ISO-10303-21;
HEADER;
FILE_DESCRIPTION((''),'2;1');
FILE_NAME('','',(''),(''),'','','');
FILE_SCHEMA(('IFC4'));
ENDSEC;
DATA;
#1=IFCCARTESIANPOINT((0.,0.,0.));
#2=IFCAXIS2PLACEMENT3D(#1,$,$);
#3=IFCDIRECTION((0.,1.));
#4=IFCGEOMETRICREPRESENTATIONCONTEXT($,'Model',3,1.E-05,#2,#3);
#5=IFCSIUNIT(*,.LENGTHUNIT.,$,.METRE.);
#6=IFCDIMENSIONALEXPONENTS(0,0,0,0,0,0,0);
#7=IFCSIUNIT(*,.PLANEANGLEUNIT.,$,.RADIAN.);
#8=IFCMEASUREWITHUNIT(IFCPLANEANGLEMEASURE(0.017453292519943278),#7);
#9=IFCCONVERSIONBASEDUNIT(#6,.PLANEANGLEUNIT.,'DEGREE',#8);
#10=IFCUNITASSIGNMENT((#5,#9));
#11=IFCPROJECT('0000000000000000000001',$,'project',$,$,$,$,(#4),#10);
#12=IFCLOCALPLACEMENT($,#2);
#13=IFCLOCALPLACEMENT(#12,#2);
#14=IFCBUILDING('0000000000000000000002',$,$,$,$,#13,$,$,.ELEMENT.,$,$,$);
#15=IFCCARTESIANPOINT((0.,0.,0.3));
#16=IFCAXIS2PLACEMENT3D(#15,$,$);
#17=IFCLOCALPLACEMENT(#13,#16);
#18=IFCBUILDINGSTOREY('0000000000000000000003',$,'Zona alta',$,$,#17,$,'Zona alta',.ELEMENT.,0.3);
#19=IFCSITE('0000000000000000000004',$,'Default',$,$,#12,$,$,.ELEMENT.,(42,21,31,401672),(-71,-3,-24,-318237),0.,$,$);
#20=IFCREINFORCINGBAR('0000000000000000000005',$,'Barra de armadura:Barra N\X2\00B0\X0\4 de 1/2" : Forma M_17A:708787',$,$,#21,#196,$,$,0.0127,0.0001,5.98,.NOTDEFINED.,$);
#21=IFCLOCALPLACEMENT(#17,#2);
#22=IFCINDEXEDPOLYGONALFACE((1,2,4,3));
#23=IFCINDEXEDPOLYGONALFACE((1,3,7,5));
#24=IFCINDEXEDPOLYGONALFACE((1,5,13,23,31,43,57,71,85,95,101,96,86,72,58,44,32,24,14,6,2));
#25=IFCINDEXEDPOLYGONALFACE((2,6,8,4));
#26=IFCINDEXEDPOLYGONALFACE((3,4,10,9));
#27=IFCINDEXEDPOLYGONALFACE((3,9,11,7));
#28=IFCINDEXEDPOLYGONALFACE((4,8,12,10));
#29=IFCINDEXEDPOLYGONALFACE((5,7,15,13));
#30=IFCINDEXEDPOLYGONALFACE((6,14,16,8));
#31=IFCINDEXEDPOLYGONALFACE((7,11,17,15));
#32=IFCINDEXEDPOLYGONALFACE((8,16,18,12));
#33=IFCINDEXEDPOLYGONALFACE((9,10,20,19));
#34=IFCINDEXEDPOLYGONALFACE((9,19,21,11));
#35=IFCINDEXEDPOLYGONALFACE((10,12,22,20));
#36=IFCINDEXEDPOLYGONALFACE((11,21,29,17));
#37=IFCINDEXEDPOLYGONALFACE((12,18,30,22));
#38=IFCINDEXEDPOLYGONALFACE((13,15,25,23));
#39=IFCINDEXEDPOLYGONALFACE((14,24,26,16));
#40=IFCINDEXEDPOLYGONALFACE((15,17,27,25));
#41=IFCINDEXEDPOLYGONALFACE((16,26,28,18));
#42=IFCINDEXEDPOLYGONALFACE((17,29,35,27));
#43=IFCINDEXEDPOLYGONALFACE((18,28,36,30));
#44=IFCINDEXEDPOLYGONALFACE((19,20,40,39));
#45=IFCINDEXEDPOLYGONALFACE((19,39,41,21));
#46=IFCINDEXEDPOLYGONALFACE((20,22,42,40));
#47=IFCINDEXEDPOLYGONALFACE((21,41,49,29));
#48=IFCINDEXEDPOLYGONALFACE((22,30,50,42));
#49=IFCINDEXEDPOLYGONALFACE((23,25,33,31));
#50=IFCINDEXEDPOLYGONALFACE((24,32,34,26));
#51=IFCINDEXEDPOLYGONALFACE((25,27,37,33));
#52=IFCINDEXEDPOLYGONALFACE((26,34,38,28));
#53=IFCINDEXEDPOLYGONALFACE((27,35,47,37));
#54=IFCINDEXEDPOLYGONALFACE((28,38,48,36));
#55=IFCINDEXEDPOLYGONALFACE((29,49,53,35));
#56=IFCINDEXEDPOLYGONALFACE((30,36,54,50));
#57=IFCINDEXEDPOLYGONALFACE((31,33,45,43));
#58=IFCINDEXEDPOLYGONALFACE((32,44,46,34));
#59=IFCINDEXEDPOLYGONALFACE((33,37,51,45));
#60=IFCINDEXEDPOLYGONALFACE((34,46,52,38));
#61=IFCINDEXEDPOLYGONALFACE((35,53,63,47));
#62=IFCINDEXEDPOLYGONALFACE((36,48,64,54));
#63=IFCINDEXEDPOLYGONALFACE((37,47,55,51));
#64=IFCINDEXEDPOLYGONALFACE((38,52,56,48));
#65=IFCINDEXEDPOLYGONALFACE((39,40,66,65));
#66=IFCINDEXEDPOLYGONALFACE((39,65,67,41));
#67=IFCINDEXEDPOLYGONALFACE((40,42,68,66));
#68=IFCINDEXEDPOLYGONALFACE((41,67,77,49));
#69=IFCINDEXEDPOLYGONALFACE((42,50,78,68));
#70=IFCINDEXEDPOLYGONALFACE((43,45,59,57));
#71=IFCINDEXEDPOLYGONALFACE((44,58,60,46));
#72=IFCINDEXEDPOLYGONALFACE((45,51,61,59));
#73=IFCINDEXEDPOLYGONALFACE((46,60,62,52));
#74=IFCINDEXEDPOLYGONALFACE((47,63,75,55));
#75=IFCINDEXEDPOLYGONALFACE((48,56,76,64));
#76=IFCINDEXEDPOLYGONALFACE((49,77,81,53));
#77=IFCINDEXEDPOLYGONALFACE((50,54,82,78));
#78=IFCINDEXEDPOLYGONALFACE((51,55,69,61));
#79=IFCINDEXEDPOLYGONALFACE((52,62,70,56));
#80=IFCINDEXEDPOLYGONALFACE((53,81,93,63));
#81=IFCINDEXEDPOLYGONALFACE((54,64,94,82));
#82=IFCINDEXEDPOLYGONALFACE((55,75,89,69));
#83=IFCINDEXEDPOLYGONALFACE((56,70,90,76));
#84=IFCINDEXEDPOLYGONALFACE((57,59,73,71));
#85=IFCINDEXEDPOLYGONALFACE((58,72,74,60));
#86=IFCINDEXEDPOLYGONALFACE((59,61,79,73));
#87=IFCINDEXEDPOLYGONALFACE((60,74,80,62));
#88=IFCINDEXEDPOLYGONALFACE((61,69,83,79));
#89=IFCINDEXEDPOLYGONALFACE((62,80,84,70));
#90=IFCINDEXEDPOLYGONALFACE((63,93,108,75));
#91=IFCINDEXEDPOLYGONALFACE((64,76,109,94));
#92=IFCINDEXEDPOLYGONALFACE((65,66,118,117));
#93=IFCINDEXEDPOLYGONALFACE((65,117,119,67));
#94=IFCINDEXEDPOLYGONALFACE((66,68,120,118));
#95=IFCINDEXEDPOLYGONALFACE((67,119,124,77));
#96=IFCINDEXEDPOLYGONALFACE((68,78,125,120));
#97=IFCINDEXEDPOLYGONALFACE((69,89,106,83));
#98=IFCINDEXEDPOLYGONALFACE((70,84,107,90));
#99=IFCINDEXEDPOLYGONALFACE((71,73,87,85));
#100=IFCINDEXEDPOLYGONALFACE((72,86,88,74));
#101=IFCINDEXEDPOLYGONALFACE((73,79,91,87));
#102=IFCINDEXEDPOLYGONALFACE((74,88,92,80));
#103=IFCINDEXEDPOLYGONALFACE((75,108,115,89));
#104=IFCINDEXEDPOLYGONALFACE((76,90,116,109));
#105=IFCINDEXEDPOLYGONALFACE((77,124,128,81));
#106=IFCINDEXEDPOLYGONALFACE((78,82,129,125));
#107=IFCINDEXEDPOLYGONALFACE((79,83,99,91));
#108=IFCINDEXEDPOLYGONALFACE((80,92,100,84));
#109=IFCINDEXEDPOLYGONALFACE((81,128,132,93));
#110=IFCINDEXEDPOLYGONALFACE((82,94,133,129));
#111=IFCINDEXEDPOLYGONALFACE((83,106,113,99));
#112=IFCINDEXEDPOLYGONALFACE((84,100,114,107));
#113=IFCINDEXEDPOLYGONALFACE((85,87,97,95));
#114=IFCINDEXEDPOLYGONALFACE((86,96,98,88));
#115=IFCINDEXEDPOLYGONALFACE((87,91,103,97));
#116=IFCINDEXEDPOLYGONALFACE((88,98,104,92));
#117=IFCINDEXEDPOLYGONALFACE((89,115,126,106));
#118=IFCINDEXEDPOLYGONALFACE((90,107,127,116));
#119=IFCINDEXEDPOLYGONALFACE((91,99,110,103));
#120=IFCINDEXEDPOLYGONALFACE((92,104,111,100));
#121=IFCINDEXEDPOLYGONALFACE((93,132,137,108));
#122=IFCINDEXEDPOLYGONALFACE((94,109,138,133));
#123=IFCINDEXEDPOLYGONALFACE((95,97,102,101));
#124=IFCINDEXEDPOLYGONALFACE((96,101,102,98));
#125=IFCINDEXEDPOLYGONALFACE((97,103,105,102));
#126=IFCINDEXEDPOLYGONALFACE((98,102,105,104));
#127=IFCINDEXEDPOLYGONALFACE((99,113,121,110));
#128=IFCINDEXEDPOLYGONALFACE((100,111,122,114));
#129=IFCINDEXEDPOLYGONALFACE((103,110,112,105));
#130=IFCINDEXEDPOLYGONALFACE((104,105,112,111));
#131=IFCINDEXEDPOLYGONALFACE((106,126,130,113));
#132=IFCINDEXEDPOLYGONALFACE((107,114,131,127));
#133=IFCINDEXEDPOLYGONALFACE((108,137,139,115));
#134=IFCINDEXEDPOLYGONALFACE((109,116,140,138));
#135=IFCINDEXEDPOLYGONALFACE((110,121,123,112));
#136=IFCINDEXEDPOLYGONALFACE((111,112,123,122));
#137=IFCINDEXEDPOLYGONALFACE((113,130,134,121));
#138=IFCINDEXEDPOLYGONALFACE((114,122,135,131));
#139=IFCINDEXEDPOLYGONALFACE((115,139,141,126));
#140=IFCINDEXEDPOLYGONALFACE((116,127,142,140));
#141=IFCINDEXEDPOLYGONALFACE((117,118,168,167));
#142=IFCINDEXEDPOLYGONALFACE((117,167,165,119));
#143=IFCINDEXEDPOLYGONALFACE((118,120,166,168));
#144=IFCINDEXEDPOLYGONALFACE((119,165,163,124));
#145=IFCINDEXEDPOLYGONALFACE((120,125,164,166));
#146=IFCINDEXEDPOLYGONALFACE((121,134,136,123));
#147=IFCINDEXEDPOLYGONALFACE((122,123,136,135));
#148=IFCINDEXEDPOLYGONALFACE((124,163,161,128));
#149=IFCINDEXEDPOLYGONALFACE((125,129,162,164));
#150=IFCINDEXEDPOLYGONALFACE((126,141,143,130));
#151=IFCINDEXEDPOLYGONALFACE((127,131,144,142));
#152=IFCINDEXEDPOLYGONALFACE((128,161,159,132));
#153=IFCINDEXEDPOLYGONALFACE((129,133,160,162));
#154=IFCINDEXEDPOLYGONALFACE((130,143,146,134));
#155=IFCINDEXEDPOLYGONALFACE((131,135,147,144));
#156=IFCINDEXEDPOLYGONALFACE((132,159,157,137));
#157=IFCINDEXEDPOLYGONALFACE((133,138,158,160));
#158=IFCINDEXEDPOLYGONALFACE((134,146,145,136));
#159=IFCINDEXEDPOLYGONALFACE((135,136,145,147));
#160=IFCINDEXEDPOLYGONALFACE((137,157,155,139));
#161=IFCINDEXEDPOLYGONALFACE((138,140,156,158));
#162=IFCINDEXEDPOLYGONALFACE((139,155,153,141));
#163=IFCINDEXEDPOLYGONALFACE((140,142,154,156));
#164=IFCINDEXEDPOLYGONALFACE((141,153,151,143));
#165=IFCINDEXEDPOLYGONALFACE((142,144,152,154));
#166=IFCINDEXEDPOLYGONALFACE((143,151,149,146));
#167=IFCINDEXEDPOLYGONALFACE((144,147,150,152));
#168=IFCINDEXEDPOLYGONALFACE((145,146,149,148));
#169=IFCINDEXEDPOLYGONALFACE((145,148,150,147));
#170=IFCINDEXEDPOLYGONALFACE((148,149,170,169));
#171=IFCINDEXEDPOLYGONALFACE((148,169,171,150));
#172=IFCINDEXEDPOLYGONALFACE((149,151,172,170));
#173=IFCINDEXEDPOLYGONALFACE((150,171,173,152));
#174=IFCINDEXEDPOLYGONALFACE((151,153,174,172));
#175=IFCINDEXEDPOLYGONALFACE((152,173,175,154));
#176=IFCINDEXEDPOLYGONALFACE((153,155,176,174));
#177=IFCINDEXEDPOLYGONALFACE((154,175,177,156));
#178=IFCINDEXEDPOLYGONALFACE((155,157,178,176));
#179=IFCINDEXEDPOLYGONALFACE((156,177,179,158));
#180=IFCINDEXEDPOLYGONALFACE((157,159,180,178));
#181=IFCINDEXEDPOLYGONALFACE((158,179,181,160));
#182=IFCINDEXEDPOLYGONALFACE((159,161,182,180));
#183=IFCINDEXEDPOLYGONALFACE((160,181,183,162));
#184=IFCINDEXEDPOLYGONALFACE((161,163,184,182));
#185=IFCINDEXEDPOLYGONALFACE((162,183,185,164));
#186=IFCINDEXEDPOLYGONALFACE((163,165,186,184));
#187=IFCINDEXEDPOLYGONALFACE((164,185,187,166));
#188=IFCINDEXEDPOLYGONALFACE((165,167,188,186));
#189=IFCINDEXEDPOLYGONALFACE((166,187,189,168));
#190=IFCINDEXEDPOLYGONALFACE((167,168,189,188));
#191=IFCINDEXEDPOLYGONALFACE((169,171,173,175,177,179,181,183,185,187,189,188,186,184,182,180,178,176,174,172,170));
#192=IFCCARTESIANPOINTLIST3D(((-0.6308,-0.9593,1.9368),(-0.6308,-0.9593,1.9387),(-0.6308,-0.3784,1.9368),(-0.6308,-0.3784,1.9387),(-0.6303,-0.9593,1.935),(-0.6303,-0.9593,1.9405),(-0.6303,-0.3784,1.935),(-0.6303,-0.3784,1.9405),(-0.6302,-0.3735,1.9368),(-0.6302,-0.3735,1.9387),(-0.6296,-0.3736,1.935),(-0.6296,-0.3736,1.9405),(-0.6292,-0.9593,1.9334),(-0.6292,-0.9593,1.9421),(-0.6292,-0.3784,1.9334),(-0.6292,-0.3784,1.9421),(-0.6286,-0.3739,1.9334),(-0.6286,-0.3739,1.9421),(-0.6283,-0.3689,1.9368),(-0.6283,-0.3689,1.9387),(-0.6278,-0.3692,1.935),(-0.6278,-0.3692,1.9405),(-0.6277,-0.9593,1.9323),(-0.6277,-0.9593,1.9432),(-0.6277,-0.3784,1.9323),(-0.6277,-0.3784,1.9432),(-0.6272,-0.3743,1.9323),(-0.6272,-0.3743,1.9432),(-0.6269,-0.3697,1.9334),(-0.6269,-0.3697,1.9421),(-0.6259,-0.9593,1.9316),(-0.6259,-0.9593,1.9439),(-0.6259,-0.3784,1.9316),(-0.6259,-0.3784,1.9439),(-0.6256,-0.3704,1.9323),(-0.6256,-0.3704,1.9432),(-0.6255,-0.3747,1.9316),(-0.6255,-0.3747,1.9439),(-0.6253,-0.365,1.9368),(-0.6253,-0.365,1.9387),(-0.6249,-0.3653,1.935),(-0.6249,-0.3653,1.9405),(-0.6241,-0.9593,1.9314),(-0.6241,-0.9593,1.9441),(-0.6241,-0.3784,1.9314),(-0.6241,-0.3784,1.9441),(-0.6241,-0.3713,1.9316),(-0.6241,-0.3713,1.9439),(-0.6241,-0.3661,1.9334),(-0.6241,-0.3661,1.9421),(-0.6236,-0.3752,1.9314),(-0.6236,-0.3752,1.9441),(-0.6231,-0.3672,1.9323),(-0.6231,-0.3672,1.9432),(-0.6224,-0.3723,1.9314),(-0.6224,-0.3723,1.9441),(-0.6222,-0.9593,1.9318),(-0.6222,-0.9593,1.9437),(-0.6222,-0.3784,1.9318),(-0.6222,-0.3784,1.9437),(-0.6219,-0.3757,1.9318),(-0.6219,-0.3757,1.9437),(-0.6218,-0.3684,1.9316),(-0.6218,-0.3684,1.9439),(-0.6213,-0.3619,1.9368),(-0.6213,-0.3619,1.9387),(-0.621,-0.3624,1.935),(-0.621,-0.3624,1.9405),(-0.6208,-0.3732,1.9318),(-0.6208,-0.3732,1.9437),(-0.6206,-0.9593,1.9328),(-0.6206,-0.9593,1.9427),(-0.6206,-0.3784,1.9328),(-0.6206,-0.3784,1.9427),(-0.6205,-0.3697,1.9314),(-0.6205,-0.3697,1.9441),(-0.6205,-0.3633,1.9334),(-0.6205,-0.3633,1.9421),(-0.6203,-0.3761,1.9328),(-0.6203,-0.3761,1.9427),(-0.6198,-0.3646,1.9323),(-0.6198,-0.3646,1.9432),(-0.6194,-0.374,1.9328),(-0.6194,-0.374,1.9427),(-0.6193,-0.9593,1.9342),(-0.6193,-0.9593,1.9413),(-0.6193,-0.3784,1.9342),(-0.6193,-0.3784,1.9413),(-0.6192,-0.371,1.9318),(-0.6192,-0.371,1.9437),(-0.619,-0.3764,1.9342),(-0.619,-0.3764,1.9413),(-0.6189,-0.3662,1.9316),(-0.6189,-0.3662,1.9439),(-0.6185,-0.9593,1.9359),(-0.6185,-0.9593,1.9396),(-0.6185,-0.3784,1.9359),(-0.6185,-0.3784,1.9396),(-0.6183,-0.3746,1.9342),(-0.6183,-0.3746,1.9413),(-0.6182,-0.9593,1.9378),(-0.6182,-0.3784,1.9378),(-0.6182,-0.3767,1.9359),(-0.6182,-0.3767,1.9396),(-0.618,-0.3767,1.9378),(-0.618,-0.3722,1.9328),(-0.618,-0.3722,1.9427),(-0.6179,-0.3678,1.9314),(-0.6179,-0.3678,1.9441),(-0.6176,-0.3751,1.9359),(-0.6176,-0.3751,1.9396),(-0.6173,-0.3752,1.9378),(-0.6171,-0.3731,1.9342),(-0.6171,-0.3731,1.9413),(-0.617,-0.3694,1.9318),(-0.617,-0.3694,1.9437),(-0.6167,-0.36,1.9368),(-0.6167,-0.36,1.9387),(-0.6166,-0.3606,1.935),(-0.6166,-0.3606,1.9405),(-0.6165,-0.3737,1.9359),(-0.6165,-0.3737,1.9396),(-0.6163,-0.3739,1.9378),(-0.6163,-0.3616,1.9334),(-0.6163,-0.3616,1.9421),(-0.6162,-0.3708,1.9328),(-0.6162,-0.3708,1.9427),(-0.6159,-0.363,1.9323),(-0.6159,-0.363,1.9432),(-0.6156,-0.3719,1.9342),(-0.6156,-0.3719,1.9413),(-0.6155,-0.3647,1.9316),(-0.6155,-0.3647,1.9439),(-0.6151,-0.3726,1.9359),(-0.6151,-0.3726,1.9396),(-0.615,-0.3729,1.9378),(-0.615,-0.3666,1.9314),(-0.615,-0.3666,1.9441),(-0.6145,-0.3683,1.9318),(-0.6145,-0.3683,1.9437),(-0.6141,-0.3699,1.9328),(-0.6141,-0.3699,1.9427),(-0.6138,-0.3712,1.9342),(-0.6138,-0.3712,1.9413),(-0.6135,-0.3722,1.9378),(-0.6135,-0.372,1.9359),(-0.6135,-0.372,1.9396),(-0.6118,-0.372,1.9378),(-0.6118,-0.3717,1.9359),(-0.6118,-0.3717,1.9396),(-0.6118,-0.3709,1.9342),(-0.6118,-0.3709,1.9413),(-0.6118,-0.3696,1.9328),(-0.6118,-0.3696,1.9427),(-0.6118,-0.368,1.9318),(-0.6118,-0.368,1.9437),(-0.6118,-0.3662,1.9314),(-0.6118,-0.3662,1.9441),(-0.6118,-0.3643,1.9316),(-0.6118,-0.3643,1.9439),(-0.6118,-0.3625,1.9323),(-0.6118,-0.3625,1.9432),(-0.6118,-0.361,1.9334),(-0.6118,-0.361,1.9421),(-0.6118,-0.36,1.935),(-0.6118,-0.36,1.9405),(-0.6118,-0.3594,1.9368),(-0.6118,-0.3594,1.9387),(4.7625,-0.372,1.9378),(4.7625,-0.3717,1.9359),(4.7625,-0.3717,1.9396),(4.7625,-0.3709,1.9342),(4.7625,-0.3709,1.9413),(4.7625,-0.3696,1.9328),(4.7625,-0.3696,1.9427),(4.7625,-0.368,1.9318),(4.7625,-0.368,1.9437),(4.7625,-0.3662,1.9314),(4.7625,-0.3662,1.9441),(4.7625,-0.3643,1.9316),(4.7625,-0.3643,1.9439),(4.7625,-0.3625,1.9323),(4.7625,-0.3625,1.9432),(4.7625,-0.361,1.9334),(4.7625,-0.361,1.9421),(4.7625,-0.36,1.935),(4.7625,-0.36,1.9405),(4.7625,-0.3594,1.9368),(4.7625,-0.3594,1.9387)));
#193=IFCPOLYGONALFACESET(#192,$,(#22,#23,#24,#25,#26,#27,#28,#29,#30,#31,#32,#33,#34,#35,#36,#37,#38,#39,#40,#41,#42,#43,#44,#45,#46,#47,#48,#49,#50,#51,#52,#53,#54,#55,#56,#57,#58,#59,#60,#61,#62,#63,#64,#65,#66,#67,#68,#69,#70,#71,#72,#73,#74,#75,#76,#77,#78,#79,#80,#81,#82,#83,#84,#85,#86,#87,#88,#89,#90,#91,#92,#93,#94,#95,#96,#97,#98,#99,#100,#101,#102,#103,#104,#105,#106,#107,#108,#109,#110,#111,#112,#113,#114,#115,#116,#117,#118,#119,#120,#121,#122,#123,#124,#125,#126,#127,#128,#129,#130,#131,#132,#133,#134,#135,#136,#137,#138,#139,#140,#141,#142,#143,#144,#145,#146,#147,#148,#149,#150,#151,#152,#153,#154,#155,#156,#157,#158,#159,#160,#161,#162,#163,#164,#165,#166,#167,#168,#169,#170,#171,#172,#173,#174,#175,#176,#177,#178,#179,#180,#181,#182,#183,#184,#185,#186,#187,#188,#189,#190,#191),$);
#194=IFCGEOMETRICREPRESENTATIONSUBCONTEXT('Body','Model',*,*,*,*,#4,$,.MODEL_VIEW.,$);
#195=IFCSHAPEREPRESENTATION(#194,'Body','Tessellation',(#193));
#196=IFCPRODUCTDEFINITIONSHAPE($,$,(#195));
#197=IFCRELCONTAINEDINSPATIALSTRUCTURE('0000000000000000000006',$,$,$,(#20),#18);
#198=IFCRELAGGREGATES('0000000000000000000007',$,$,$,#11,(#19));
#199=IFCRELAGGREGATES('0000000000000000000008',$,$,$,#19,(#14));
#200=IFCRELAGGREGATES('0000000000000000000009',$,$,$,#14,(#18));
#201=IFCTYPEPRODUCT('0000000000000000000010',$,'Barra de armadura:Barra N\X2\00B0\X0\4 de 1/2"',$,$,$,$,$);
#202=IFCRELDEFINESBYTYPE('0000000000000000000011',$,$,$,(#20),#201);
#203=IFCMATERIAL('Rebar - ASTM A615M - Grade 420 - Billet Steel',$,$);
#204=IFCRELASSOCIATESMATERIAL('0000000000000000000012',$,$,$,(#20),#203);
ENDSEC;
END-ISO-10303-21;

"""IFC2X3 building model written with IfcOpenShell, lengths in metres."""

from ifc_helpers import new_model, entity, si_unit, converted_unit, direction, frame, origin, place, context, subcontext, project, spatial, material, type_object, element, save


model = new_model("IFC2X3")

# Units and contexts
model_context = context("Model", 3, precision=1e-05, world=origin(), true_north=direction((0.0, 1.0)))
body_context = subcontext(model_context, "Body", "Model", "MODEL_VIEW")
ifc_project = project(units=[si_unit("LENGTHUNIT", "METRE"), converted_unit("PLANEANGLEUNIT", "DEGREE", entity("IfcPlaneAngleMeasure", 0.017453292519943278), si_unit("PLANEANGLEUNIT", "RADIAN"), dimensions=[0, 0, 0, 0, 0, 0, 0])], contexts=[model_context])

# Site, building, storey
site_placement = place(None, origin())
site = spatial("IfcSite", under=ifc_project, at=site_placement, Name="Default", CompositionType="ELEMENT", RefLatitude=(42, 21, 31, 401672), RefLongitude=(-71, -3, -24, -318237), RefElevation=0.0)
building_placement = place(site_placement, origin())
building = spatial("IfcBuilding", under=site, at=building_placement, CompositionType="ELEMENT")
storey_placement = place(building_placement, frame((0.0, 0.0, 0.3)))
storey = spatial("IfcBuildingStorey", under=building, at=storey_placement, Name="Zona alta", LongName="Zona alta", CompositionType="ELEMENT", Elevation=0.3)

# Reinforcing bar
ifc_material = material(Name="Rebar - ASTM A615M - Grade 420 - Billet Steel")
type_product_1 = type_object("IfcTypeProduct", Name="Barra de armadura:Barra N°4 de 1/2\"")
reinforcing_bar_1_placement = place(storey_placement, origin())
element("IfcReinforcingBar", 1, at=reinforcing_bar_1_placement, inside=storey, type_object=type_product_1, material=ifc_material, Name="Barra de armadura:Barra N°4 de 1/2\" : Forma M_17A:708787", BarLength=5.98, BarRole="NOTDEFINED", CrossSectionArea=0.0001, NominalDiameter=0.0127, context=body_context, shape_type="AdvancedSweptSolid", body=[
    entity("IfcSweptDiskSolid", entity("IfcCompositeCurve", [entity("IfcCompositeCurveSegment", "CONTINUOUS", True, entity("IfcPolyline", [entity("IfcCartesianPoint", [4.7625, -0.3657, 1.9378]), entity("IfcCartesianPoint", [-0.6118, -0.3657, 1.9378])])), entity("IfcCompositeCurveSegment", "CONTINUOUS", True, entity("IfcTrimmedCurve", entity("IfcCircle", entity("IfcAxis2Placement3D", entity("IfcCartesianPoint", [-0.6118, -0.3784, 1.9378]), entity("IfcDirection", [0.0, 0.0, 1.0]), entity("IfcDirection", [-1.0, 0.0, 0.0])), 0.0127), [entity("IfcParameterValue", 270.0)], [entity("IfcParameterValue", 360.0)], True, "PARAMETER")), entity("IfcCompositeCurveSegment", "CONTINUOUS", True, entity("IfcPolyline", [entity("IfcCartesianPoint", [-0.6245, -0.3784, 1.9378]), entity("IfcCartesianPoint", [-0.6245, -0.9593, 1.9378])]))], False), 0.0063, None, 0.0, 92.0),
])

save(model, "model.ifc")
